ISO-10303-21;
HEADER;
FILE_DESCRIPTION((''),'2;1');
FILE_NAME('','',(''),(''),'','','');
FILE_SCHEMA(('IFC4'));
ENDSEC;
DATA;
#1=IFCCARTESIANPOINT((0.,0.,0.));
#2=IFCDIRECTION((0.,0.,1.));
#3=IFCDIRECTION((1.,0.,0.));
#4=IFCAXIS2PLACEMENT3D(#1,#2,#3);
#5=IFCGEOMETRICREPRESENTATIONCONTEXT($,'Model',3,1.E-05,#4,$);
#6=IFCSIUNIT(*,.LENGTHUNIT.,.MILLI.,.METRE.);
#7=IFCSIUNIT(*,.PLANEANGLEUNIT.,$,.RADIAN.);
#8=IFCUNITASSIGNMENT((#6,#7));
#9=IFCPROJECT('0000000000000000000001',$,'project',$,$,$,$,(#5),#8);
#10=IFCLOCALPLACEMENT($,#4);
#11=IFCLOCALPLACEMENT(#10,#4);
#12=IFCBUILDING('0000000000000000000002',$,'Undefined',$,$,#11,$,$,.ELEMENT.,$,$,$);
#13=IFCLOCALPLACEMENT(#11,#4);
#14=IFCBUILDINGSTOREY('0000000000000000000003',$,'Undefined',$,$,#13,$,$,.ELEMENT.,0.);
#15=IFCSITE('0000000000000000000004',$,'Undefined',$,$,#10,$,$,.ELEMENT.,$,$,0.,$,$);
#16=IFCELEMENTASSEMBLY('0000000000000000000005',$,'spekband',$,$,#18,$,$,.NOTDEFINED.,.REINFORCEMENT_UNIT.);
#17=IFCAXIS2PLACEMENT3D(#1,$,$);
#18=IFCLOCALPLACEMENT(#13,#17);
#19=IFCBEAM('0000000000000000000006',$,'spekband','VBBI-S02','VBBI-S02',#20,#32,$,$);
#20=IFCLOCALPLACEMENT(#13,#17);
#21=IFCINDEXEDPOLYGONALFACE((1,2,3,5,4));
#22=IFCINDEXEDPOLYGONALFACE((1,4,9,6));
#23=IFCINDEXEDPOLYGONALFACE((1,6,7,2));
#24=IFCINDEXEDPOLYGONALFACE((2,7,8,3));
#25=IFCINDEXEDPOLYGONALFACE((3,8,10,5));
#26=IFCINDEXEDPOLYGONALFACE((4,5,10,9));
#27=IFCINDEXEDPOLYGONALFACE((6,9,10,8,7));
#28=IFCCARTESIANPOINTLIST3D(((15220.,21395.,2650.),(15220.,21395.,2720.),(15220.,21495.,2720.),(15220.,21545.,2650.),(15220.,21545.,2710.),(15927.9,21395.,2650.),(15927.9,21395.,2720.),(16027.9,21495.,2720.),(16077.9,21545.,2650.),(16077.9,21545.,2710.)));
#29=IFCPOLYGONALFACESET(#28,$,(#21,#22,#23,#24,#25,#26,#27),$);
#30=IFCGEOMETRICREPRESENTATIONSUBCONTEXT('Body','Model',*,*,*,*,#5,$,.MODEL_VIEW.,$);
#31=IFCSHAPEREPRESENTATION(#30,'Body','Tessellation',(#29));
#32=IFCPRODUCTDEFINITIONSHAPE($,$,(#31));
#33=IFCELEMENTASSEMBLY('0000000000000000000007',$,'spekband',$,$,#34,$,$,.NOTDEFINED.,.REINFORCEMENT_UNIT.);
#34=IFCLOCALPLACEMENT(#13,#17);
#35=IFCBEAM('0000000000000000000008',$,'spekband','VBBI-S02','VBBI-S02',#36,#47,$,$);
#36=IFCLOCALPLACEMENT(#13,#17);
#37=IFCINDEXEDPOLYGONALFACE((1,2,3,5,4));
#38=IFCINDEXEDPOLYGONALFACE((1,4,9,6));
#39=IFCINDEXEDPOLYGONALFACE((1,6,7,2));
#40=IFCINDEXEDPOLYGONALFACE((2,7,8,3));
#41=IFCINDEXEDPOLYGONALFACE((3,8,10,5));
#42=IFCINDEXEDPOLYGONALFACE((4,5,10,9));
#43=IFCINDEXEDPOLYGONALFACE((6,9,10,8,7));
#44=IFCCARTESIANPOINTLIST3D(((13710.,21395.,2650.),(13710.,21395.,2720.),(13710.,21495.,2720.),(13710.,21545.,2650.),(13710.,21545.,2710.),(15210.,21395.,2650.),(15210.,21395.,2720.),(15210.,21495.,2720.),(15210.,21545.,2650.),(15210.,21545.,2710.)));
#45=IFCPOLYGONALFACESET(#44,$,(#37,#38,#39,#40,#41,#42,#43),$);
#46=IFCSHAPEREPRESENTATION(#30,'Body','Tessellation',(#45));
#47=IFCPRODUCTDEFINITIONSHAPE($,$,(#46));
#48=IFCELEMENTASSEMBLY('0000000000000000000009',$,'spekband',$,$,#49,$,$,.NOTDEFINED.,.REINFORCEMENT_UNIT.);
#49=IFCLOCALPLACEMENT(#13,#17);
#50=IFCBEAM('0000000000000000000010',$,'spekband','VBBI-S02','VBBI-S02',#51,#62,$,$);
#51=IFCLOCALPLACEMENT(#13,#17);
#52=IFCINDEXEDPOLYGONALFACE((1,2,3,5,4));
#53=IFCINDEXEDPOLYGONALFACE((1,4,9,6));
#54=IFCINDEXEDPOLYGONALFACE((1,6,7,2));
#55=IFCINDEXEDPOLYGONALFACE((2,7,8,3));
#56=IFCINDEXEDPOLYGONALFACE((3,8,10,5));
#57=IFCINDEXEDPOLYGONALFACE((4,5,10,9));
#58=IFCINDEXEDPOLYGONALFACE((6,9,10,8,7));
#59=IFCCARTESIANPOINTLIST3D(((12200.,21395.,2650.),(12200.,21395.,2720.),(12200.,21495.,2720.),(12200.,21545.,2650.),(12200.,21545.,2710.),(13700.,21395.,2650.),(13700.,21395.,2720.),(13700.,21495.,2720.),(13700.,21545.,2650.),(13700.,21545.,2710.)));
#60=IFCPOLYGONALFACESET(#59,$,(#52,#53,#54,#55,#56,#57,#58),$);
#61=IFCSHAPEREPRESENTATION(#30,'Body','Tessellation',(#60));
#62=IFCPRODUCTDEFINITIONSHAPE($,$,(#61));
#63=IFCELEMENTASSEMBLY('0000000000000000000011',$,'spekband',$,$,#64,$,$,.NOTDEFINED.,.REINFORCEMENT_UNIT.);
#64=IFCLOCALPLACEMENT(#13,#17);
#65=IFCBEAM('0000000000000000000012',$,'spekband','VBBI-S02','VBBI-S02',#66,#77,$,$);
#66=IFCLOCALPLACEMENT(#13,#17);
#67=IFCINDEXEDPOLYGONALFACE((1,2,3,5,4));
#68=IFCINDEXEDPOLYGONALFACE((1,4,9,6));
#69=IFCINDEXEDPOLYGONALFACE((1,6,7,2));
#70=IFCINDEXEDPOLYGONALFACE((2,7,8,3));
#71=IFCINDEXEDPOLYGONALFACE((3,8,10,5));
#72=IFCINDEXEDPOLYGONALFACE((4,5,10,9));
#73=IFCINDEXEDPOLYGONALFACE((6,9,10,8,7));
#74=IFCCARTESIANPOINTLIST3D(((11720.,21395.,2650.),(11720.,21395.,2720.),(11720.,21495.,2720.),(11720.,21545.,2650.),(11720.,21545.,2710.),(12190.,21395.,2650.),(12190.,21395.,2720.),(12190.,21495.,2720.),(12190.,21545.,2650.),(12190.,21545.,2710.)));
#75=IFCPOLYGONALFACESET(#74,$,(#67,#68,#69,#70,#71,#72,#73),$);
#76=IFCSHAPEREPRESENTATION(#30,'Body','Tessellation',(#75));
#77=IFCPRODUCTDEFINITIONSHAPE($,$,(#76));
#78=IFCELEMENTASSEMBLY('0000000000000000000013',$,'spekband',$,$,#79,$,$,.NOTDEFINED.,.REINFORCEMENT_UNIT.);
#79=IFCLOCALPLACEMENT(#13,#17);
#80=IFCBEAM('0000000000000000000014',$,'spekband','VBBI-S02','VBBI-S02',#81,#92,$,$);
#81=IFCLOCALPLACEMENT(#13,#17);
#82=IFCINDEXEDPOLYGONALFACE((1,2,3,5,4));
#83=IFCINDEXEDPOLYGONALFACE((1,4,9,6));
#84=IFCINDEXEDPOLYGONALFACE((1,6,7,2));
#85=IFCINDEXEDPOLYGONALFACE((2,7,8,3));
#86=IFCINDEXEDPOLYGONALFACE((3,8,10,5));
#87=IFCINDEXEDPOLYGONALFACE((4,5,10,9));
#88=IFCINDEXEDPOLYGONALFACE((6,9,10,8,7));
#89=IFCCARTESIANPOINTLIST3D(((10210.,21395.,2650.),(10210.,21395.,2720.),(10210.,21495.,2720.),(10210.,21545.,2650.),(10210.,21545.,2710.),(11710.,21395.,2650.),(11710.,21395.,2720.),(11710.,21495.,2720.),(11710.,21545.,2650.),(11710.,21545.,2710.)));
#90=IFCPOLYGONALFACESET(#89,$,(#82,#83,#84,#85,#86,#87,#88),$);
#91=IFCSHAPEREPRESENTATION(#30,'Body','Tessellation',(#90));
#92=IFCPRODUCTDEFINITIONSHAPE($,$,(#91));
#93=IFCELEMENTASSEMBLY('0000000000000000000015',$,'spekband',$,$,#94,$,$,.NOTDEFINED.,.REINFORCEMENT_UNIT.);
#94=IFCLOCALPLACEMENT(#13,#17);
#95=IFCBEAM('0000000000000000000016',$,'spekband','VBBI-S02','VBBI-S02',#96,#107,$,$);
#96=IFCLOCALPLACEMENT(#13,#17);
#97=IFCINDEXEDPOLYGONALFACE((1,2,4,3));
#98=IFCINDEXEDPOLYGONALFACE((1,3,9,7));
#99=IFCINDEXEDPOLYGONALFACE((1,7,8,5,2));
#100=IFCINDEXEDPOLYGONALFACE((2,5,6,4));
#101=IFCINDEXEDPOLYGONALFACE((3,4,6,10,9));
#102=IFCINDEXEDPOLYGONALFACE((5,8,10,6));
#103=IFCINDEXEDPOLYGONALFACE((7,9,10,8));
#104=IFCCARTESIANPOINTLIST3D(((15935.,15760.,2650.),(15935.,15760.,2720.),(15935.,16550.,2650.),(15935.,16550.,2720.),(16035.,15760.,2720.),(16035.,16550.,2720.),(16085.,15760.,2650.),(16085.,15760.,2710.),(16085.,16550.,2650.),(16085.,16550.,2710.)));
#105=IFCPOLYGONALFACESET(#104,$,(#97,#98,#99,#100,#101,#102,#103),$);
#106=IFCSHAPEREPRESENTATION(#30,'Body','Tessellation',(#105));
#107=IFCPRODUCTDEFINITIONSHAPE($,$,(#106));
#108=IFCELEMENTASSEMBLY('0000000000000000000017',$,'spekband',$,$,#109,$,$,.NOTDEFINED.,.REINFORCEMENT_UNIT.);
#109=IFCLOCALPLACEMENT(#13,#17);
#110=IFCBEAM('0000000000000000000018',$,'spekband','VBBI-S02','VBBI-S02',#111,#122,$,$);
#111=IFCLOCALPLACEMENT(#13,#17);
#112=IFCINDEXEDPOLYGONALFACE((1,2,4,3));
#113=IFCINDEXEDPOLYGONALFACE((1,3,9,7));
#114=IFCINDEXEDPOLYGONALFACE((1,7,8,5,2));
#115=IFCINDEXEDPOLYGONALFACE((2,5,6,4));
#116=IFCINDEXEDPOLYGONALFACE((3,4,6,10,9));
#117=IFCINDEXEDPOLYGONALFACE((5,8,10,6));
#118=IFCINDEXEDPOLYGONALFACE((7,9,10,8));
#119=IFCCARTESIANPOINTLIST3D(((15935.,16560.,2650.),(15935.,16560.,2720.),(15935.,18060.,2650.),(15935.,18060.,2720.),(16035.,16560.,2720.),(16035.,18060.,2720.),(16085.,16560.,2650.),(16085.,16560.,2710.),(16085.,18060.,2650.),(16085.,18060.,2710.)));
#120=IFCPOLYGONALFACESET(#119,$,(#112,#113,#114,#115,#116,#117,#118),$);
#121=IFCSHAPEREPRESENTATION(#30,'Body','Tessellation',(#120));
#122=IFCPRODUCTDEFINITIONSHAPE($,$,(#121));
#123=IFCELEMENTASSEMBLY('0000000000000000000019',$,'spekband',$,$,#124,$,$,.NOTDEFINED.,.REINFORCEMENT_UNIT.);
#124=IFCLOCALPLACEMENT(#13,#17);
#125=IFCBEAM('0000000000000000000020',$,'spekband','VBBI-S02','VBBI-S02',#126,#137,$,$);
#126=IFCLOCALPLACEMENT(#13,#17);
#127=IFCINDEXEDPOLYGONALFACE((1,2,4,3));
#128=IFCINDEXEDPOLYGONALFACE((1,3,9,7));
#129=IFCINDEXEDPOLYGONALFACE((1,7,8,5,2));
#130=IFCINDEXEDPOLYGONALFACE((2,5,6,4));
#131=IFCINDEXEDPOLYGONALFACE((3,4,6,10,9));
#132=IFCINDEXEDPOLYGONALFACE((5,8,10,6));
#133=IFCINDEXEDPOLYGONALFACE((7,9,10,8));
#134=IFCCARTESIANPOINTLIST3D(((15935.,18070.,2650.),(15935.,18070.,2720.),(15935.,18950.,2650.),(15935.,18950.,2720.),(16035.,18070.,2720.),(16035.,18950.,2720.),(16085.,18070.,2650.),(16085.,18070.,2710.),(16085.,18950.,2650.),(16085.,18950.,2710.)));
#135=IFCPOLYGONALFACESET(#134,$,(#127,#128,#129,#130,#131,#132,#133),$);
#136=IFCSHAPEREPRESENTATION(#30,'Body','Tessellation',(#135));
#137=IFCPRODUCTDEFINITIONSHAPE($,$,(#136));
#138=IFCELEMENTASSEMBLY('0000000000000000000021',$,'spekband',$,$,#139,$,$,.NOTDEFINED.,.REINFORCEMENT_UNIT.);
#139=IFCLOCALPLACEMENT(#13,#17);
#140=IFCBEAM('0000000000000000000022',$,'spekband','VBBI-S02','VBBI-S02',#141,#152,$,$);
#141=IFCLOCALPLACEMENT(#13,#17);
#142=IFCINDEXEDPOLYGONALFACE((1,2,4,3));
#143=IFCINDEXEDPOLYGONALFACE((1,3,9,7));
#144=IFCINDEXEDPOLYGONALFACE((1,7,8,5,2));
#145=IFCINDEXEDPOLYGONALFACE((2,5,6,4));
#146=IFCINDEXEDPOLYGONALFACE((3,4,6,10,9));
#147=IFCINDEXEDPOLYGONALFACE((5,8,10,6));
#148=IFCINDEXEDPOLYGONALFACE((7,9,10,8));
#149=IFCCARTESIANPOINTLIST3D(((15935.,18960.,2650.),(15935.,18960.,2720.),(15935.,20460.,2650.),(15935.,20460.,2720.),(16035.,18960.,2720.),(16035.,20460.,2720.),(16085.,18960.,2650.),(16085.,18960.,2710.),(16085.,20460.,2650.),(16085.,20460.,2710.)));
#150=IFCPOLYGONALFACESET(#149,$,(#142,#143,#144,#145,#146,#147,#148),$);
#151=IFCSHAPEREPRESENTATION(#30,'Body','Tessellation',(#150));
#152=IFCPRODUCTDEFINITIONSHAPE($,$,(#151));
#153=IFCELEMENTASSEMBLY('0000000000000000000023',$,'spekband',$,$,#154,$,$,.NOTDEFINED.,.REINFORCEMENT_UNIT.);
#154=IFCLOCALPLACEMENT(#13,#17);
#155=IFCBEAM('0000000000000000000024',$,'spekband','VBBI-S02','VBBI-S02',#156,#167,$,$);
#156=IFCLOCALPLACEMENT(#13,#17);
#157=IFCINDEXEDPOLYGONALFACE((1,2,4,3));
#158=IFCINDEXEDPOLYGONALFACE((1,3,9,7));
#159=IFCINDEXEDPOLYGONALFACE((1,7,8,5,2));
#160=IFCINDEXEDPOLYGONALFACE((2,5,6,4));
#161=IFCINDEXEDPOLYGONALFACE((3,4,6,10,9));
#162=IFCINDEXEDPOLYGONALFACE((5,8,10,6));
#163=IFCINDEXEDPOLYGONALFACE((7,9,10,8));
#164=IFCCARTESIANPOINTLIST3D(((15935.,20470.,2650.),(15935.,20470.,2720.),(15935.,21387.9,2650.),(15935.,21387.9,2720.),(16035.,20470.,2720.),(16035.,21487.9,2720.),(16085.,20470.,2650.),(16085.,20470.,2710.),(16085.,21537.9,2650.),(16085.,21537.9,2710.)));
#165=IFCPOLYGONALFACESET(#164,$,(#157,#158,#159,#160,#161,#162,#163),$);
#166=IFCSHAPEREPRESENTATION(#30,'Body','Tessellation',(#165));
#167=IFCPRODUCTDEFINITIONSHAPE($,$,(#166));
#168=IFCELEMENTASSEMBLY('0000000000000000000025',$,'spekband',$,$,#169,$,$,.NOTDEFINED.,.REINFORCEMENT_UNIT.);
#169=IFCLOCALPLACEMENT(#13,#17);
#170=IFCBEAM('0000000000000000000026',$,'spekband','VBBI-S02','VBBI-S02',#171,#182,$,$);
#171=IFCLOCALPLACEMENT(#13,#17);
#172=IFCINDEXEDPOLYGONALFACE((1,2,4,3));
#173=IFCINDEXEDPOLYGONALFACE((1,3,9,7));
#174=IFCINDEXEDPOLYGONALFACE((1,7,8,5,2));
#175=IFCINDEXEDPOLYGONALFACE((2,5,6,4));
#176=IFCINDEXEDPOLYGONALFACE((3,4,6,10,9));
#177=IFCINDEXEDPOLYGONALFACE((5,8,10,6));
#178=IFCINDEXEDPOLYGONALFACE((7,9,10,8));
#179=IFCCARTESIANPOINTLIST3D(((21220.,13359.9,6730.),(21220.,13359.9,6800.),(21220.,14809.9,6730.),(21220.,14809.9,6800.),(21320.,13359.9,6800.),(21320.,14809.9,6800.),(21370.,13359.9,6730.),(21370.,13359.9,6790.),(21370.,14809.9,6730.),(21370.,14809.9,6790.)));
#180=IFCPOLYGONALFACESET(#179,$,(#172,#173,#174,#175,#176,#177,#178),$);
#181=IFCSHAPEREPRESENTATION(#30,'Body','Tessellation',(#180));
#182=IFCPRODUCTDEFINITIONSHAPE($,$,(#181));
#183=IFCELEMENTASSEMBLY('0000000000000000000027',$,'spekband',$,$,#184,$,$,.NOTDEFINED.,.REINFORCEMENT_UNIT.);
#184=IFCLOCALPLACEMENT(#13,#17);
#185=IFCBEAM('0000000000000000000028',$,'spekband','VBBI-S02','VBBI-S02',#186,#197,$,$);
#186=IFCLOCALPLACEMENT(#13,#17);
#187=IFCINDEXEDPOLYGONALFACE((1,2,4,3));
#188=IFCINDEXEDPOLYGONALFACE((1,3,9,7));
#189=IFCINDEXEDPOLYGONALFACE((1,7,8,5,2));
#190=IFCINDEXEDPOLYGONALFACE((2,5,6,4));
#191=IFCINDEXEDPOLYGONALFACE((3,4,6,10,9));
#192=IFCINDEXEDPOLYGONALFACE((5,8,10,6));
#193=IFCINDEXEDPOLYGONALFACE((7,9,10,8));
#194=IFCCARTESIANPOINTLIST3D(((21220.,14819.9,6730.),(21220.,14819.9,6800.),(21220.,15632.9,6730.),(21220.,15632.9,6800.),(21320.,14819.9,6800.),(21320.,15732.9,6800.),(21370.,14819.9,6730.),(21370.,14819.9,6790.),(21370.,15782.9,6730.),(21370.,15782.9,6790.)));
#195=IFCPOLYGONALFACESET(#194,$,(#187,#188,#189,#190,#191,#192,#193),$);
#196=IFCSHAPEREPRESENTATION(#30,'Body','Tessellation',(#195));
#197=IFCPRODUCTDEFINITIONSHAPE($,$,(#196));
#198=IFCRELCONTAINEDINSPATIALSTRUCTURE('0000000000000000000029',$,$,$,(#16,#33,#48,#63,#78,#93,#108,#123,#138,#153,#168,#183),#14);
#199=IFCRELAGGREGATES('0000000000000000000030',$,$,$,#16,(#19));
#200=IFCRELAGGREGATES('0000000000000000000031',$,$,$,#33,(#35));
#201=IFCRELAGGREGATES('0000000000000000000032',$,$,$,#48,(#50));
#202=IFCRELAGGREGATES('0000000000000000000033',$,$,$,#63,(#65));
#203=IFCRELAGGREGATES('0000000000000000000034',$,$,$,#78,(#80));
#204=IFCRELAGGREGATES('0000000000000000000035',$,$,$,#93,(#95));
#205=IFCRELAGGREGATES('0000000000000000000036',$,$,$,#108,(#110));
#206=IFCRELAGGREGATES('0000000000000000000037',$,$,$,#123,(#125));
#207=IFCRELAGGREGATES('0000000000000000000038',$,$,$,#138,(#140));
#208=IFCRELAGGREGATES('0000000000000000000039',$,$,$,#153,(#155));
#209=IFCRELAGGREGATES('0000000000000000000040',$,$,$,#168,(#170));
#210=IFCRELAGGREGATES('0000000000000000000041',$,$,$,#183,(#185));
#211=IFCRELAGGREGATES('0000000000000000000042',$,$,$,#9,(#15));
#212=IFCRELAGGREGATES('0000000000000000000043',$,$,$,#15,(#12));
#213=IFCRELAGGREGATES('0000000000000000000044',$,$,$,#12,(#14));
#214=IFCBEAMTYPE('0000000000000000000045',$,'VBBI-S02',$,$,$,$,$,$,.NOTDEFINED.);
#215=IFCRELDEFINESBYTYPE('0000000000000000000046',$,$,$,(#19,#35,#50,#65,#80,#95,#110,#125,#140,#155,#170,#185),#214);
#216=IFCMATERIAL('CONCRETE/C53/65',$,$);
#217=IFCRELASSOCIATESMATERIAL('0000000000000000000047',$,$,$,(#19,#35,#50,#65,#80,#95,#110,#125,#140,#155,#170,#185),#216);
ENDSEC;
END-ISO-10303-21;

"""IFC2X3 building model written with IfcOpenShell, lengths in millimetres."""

from ifc_helpers import new_model, si_unit, frame, origin_with_axes, place, context, subcontext, project, spatial, polyline, outline, extrude, clip, halfspace, material, type_object, element, aggregate, save


model = new_model("IFC2X3")

# Units and contexts
model_context = context("Model", 3, precision=1e-05, world=origin_with_axes())
body_context = subcontext(model_context, "Body", "Model", "MODEL_VIEW")
ifc_project = project(units=[si_unit("LENGTHUNIT", "METRE", prefix="MILLI"), si_unit("PLANEANGLEUNIT", "RADIAN")], contexts=[model_context])

# Site, building, storey
site_placement = place(None, origin_with_axes())
site = spatial("IfcSite", under=ifc_project, at=site_placement, Name="Undefined", CompositionType="ELEMENT", RefElevation=0.0)
building_placement = place(site_placement, origin_with_axes())
building = spatial("IfcBuilding", under=site, at=building_placement, Name="Undefined", CompositionType="ELEMENT")
storey_placement = place(building_placement, origin_with_axes())
storey = spatial("IfcBuildingStorey", under=building, at=storey_placement, Name="Undefined", CompositionType="ELEMENT", Elevation=0.0)

# Element assemblies, beams
assembly_1_placement = place(storey_placement, origin_with_axes())
assembly_1 = element("IfcElementAssembly", 1, at=assembly_1_placement, inside=storey, Name="spekband", AssemblyPlace="NOTDEFINED", PredefinedType="REINFORCEMENT_UNIT")
ifc_material = material(Name="CONCRETE/C53/65")
beam_type_1 = type_object("IfcBeamType", Name="VBBI-S02", PredefinedType="NOTDEFINED")
beam_1_placement = place(assembly_1_placement, frame((16085.0, 21470.0, 2685.0), z_axis=(0.0, 1.0, 0.0), x_axis=(-1.0, 0.0, 0.0)))
beam_1 = element("IfcBeam", 2, at=beam_1_placement, type_object=beam_type_1, material=ifc_material, Name="spekband", Description="VBBI-S02", ObjectType="VBBI-S02", context=body_context, shape_type="Clipping", body=[
    clip(extrude(outline(polyline([(35.0, -75.0), (-35.0, -75.0), (-35.0, 25.0), (-25.0, 75.0), (35.0, 75.0), (35.0, -75.0)])), frame((865.0, 0.0, 0.0), z_axis=(-1.0, 0.0, 0.0), x_axis=(0.0, -1.0, 0.0)), (0.0, 0.0, 1.0), 858.7), halfspace(frame((3.5, 0.0, 78.5), z_axis=(0.707107, 0.0, 0.707106), x_axis=(0.0, 1.0, 0.0)), True)),
])
aggregate(assembly_1, [beam_1])
assembly_2_placement = place(storey_placement, origin_with_axes())
assembly_2 = element("IfcElementAssembly", 3, at=assembly_2_placement, inside=storey, Name="spekband", AssemblyPlace="NOTDEFINED", PredefinedType="REINFORCEMENT_UNIT")
beam_2_placement = place(assembly_2_placement, frame((15210.0, 21470.0, 2685.0), z_axis=(0.0, 1.0, 0.0), x_axis=(-1.0, 0.0, 0.0)))
beam_2 = element("IfcBeam", 4, at=beam_2_placement, type_object=beam_type_1, material=ifc_material, Name="spekband", Description="VBBI-S02", ObjectType="VBBI-S02", context=body_context, shape_type="SweptSolid", body=[
    extrude(outline(polyline([(35.0, -75.0), (-35.0, -75.0), (-35.0, 25.0), (-25.0, 75.0), (35.0, 75.0), (35.0, -75.0)])), frame((1500.0, 0.0, 0.0), z_axis=(-1.0, 0.0, 0.0), x_axis=(0.0, -1.0, 0.0)), (0.0, 0.0, 1.0), 1500.0),
])
aggregate(assembly_2, [beam_2])
assembly_3_placement = place(storey_placement, origin_with_axes())
assembly_3 = element("IfcElementAssembly", 5, at=assembly_3_placement, inside=storey, Name="spekband", AssemblyPlace="NOTDEFINED", PredefinedType="REINFORCEMENT_UNIT")
beam_3_placement = place(assembly_3_placement, frame((13700.0, 21470.0, 2685.0), z_axis=(0.0, 1.0, 0.0), x_axis=(-1.0, 0.0, 0.0)))
beam_3 = element("IfcBeam", 6, at=beam_3_placement, type_object=beam_type_1, material=ifc_material, Name="spekband", Description="VBBI-S02", ObjectType="VBBI-S02", context=body_context, shape_type="SweptSolid", body=[
    extrude(outline(polyline([(35.0, -75.0), (-35.0, -75.0), (-35.0, 25.0), (-25.0, 75.0), (35.0, 75.0), (35.0, -75.0)])), frame((1500.0, 0.0, 0.0), z_axis=(-1.0, 0.0, 0.0), x_axis=(0.0, -1.0, 0.0)), (0.0, 0.0, 1.0), 1500.0),
])
aggregate(assembly_3, [beam_3])
assembly_4_placement = place(storey_placement, origin_with_axes())
assembly_4 = element("IfcElementAssembly", 7, at=assembly_4_placement, inside=storey, Name="spekband", AssemblyPlace="NOTDEFINED", PredefinedType="REINFORCEMENT_UNIT")
beam_4_placement = place(assembly_4_placement, frame((12190.0, 21470.0, 2685.0), z_axis=(0.0, 1.0, 0.0), x_axis=(-1.0, 0.0, 0.0)))
beam_4 = element("IfcBeam", 8, at=beam_4_placement, type_object=beam_type_1, material=ifc_material, Name="spekband", Description="VBBI-S02", ObjectType="VBBI-S02", context=body_context, shape_type="SweptSolid", body=[
    extrude(outline(polyline([(35.0, -75.0), (-35.0, -75.0), (-35.0, 25.0), (-25.0, 75.0), (35.0, 75.0), (35.0, -75.0)])), frame((470.0, 0.0, 0.0), z_axis=(-1.0, 0.0, 0.0), x_axis=(0.0, -1.0, 0.0)), (0.0, 0.0, 1.0), 470.0),
])
aggregate(assembly_4, [beam_4])
assembly_5_placement = place(storey_placement, origin_with_axes())
assembly_5 = element("IfcElementAssembly", 9, at=assembly_5_placement, inside=storey, Name="spekband", AssemblyPlace="NOTDEFINED", PredefinedType="REINFORCEMENT_UNIT")
beam_5_placement = place(assembly_5_placement, frame((11710.0, 21470.0, 2685.0), z_axis=(0.0, 1.0, 0.0), x_axis=(-1.0, 0.0, 0.0)))
beam_5 = element("IfcBeam", 10, at=beam_5_placement, type_object=beam_type_1, material=ifc_material, Name="spekband", Description="VBBI-S02", ObjectType="VBBI-S02", context=body_context, shape_type="SweptSolid", body=[
    extrude(outline(polyline([(35.0, -75.0), (-35.0, -75.0), (-35.0, 25.0), (-25.0, 75.0), (35.0, 75.0), (35.0, -75.0)])), frame((1500.0, 0.0, 0.0), z_axis=(-1.0, 0.0, 0.0), x_axis=(0.0, -1.0, 0.0)), (0.0, 0.0, 1.0), 1500.0),
])
aggregate(assembly_5, [beam_5])
assembly_6_placement = place(storey_placement, origin_with_axes())
assembly_6 = element("IfcElementAssembly", 11, at=assembly_6_placement, inside=storey, Name="spekband", AssemblyPlace="NOTDEFINED", PredefinedType="REINFORCEMENT_UNIT")
beam_6_placement = place(assembly_6_placement, frame((16010.0, 15760.0, 2685.0), z_axis=(1.0, 0.000002, 0.0), x_axis=(-0.000002, 1.0, 0.0)))
beam_6 = element("IfcBeam", 12, at=beam_6_placement, type_object=beam_type_1, material=ifc_material, Name="spekband", Description="VBBI-S02", ObjectType="VBBI-S02", context=body_context, shape_type="SweptSolid", body=[
    extrude(outline(polyline([(35.0, -75.0), (-35.0, -75.0), (-35.0, 25.0), (-25.0, 75.0), (35.0, 75.0), (35.0, -75.0)])), frame((790.0, 0.0, 0.0), z_axis=(-1.0, 0.0, 0.0), x_axis=(0.0, -1.0, 0.0)), (0.0, 0.0, 1.0), 790.0),
])
aggregate(assembly_6, [beam_6])
assembly_7_placement = place(storey_placement, origin_with_axes())
assembly_7 = element("IfcElementAssembly", 13, at=assembly_7_placement, inside=storey, Name="spekband", AssemblyPlace="NOTDEFINED", PredefinedType="REINFORCEMENT_UNIT")
beam_7_placement = place(assembly_7_placement, frame((16010.0, 16560.0, 2685.0), z_axis=(1.0, 0.000001, 0.0), x_axis=(-0.000001, 1.0, 0.0)))
beam_7 = element("IfcBeam", 14, at=beam_7_placement, type_object=beam_type_1, material=ifc_material, Name="spekband", Description="VBBI-S02", ObjectType="VBBI-S02", context=body_context, shape_type="SweptSolid", body=[
    extrude(outline(polyline([(35.0, -75.0), (-35.0, -75.0), (-35.0, 25.0), (-25.0, 75.0), (35.0, 75.0), (35.0, -75.0)])), frame((1500.0, 0.0, 0.0), z_axis=(-1.0, 0.0, 0.0), x_axis=(0.0, -1.0, 0.0)), (0.0, 0.0, 1.0), 1500.0),
])
aggregate(assembly_7, [beam_7])
assembly_8_placement = place(storey_placement, origin_with_axes())
assembly_8 = element("IfcElementAssembly", 15, at=assembly_8_placement, inside=storey, Name="spekband", AssemblyPlace="NOTDEFINED", PredefinedType="REINFORCEMENT_UNIT")
beam_8_placement = place(assembly_8_placement, frame((16010.0, 18070.0, 2685.0), z_axis=(1.0, 0.000002, 0.0), x_axis=(-0.000002, 1.0, 0.0)))
beam_8 = element("IfcBeam", 16, at=beam_8_placement, type_object=beam_type_1, material=ifc_material, Name="spekband", Description="VBBI-S02", ObjectType="VBBI-S02", context=body_context, shape_type="SweptSolid", body=[
    extrude(outline(polyline([(35.0, -75.0), (-35.0, -75.0), (-35.0, 25.0), (-25.0, 75.0), (35.0, 75.0), (35.0, -75.0)])), frame((880.0, 0.0, 0.0), z_axis=(-1.0, 0.0, 0.0), x_axis=(0.0, -1.0, 0.0)), (0.0, 0.0, 1.0), 880.0),
])
aggregate(assembly_8, [beam_8])
assembly_9_placement = place(storey_placement, origin_with_axes())
assembly_9 = element("IfcElementAssembly", 17, at=assembly_9_placement, inside=storey, Name="spekband", AssemblyPlace="NOTDEFINED", PredefinedType="REINFORCEMENT_UNIT")
beam_9_placement = place(assembly_9_placement, frame((16010.0, 18960.0, 2685.0), z_axis=(1.0, 0.000001, 0.0), x_axis=(-0.000001, 1.0, 0.0)))
beam_9 = element("IfcBeam", 18, at=beam_9_placement, type_object=beam_type_1, material=ifc_material, Name="spekband", Description="VBBI-S02", ObjectType="VBBI-S02", context=body_context, shape_type="SweptSolid", body=[
    extrude(outline(polyline([(35.0, -75.0), (-35.0, -75.0), (-35.0, 25.0), (-25.0, 75.0), (35.0, 75.0), (35.0, -75.0)])), frame((1500.0, 0.0, 0.0), z_axis=(-1.0, 0.0, 0.0), x_axis=(0.0, -1.0, 0.0)), (0.0, 0.0, 1.0), 1500.0),
])
aggregate(assembly_9, [beam_9])
assembly_10_placement = place(storey_placement, origin_with_axes())
assembly_10 = element("IfcElementAssembly", 19, at=assembly_10_placement, inside=storey, Name="spekband", AssemblyPlace="NOTDEFINED", PredefinedType="REINFORCEMENT_UNIT")
beam_10_placement = place(assembly_10_placement, frame((16010.0, 20470.0, 2685.0), z_axis=(1.0, 0.000002, 0.0), x_axis=(-0.000002, 1.0, 0.0)))
beam_10 = element("IfcBeam", 20, at=beam_10_placement, type_object=beam_type_1, material=ifc_material, Name="spekband", Description="VBBI-S02", ObjectType="VBBI-S02", context=body_context, shape_type="Clipping", body=[
    clip(extrude(outline(polyline([(35.0, -75.0), (-35.0, -75.0), (-35.0, 25.0), (-25.0, 75.0), (35.0, 75.0), (35.0, -75.0)])), frame((1068.7, 0.0, 0.0), z_axis=(-1.0, 0.0, 0.0), x_axis=(0.0, -1.0, 0.0)), (0.0, 0.0, 1.0), 1068.7), halfspace(frame((1071.5, 0.0, 78.5), z_axis=(0.707107, 0.0, -0.707107), x_axis=(0.0, 1.0, 0.0)), False)),
])
aggregate(assembly_10, [beam_10])
assembly_11_placement = place(storey_placement, origin_with_axes())
assembly_11 = element("IfcElementAssembly", 21, at=assembly_11_placement, inside=storey, Name="spekband", AssemblyPlace="NOTDEFINED", PredefinedType="REINFORCEMENT_UNIT")
beam_11_placement = place(assembly_11_placement, frame((21295.0, 13359.9, 6765.0), z_axis=(1.0, 0.0, 0.0), x_axis=(0.0, 1.0, 0.0)))
beam_11 = element("IfcBeam", 22, at=beam_11_placement, type_object=beam_type_1, material=ifc_material, Name="spekband", Description="VBBI-S02", ObjectType="VBBI-S02", context=body_context, shape_type="SweptSolid", body=[
    extrude(outline(polyline([(35.0, -75.0), (-35.0, -75.0), (-35.0, 25.0), (-25.0, 75.0), (35.0, 75.0), (35.0, -75.0)])), frame((1450.0, 0.0, 0.0), z_axis=(-1.0, 0.0, 0.0), x_axis=(0.0, -1.0, 0.0)), (0.0, 0.0, 1.0), 1450.0),
])
aggregate(assembly_11, [beam_11])
assembly_12_placement = place(storey_placement, origin_with_axes())
assembly_12 = element("IfcElementAssembly", 23, at=assembly_12_placement, inside=storey, Name="spekband", AssemblyPlace="NOTDEFINED", PredefinedType="REINFORCEMENT_UNIT")
beam_12_placement = place(assembly_12_placement, frame((21295.0, 14819.9, 6765.0), z_axis=(1.0, 0.000002, 0.0), x_axis=(-0.000002, 1.0, 0.0)))
beam_12 = element("IfcBeam", 24, at=beam_12_placement, type_object=beam_type_1, material=ifc_material, Name="spekband", Description="VBBI-S02", ObjectType="VBBI-S02", context=body_context, shape_type="Clipping", body=[
    clip(extrude(outline(polyline([(35.0, -75.0), (-35.0, -75.0), (-35.0, 25.0), (-25.0, 75.0), (35.0, 75.0), (35.0, -75.0)])), frame((963.7, 0.0, 0.0), z_axis=(-1.0, 0.0, 0.0), x_axis=(0.0, -1.0, 0.0)), (0.0, 0.0, 1.0), 963.7), halfspace(frame((966.5, 0.0, 78.5), z_axis=(0.707156, 0.0, -0.707057), x_axis=(0.0, 1.0, 0.0)), False)),
])
aggregate(assembly_12, [beam_12])

save(model, "model.ifc")
